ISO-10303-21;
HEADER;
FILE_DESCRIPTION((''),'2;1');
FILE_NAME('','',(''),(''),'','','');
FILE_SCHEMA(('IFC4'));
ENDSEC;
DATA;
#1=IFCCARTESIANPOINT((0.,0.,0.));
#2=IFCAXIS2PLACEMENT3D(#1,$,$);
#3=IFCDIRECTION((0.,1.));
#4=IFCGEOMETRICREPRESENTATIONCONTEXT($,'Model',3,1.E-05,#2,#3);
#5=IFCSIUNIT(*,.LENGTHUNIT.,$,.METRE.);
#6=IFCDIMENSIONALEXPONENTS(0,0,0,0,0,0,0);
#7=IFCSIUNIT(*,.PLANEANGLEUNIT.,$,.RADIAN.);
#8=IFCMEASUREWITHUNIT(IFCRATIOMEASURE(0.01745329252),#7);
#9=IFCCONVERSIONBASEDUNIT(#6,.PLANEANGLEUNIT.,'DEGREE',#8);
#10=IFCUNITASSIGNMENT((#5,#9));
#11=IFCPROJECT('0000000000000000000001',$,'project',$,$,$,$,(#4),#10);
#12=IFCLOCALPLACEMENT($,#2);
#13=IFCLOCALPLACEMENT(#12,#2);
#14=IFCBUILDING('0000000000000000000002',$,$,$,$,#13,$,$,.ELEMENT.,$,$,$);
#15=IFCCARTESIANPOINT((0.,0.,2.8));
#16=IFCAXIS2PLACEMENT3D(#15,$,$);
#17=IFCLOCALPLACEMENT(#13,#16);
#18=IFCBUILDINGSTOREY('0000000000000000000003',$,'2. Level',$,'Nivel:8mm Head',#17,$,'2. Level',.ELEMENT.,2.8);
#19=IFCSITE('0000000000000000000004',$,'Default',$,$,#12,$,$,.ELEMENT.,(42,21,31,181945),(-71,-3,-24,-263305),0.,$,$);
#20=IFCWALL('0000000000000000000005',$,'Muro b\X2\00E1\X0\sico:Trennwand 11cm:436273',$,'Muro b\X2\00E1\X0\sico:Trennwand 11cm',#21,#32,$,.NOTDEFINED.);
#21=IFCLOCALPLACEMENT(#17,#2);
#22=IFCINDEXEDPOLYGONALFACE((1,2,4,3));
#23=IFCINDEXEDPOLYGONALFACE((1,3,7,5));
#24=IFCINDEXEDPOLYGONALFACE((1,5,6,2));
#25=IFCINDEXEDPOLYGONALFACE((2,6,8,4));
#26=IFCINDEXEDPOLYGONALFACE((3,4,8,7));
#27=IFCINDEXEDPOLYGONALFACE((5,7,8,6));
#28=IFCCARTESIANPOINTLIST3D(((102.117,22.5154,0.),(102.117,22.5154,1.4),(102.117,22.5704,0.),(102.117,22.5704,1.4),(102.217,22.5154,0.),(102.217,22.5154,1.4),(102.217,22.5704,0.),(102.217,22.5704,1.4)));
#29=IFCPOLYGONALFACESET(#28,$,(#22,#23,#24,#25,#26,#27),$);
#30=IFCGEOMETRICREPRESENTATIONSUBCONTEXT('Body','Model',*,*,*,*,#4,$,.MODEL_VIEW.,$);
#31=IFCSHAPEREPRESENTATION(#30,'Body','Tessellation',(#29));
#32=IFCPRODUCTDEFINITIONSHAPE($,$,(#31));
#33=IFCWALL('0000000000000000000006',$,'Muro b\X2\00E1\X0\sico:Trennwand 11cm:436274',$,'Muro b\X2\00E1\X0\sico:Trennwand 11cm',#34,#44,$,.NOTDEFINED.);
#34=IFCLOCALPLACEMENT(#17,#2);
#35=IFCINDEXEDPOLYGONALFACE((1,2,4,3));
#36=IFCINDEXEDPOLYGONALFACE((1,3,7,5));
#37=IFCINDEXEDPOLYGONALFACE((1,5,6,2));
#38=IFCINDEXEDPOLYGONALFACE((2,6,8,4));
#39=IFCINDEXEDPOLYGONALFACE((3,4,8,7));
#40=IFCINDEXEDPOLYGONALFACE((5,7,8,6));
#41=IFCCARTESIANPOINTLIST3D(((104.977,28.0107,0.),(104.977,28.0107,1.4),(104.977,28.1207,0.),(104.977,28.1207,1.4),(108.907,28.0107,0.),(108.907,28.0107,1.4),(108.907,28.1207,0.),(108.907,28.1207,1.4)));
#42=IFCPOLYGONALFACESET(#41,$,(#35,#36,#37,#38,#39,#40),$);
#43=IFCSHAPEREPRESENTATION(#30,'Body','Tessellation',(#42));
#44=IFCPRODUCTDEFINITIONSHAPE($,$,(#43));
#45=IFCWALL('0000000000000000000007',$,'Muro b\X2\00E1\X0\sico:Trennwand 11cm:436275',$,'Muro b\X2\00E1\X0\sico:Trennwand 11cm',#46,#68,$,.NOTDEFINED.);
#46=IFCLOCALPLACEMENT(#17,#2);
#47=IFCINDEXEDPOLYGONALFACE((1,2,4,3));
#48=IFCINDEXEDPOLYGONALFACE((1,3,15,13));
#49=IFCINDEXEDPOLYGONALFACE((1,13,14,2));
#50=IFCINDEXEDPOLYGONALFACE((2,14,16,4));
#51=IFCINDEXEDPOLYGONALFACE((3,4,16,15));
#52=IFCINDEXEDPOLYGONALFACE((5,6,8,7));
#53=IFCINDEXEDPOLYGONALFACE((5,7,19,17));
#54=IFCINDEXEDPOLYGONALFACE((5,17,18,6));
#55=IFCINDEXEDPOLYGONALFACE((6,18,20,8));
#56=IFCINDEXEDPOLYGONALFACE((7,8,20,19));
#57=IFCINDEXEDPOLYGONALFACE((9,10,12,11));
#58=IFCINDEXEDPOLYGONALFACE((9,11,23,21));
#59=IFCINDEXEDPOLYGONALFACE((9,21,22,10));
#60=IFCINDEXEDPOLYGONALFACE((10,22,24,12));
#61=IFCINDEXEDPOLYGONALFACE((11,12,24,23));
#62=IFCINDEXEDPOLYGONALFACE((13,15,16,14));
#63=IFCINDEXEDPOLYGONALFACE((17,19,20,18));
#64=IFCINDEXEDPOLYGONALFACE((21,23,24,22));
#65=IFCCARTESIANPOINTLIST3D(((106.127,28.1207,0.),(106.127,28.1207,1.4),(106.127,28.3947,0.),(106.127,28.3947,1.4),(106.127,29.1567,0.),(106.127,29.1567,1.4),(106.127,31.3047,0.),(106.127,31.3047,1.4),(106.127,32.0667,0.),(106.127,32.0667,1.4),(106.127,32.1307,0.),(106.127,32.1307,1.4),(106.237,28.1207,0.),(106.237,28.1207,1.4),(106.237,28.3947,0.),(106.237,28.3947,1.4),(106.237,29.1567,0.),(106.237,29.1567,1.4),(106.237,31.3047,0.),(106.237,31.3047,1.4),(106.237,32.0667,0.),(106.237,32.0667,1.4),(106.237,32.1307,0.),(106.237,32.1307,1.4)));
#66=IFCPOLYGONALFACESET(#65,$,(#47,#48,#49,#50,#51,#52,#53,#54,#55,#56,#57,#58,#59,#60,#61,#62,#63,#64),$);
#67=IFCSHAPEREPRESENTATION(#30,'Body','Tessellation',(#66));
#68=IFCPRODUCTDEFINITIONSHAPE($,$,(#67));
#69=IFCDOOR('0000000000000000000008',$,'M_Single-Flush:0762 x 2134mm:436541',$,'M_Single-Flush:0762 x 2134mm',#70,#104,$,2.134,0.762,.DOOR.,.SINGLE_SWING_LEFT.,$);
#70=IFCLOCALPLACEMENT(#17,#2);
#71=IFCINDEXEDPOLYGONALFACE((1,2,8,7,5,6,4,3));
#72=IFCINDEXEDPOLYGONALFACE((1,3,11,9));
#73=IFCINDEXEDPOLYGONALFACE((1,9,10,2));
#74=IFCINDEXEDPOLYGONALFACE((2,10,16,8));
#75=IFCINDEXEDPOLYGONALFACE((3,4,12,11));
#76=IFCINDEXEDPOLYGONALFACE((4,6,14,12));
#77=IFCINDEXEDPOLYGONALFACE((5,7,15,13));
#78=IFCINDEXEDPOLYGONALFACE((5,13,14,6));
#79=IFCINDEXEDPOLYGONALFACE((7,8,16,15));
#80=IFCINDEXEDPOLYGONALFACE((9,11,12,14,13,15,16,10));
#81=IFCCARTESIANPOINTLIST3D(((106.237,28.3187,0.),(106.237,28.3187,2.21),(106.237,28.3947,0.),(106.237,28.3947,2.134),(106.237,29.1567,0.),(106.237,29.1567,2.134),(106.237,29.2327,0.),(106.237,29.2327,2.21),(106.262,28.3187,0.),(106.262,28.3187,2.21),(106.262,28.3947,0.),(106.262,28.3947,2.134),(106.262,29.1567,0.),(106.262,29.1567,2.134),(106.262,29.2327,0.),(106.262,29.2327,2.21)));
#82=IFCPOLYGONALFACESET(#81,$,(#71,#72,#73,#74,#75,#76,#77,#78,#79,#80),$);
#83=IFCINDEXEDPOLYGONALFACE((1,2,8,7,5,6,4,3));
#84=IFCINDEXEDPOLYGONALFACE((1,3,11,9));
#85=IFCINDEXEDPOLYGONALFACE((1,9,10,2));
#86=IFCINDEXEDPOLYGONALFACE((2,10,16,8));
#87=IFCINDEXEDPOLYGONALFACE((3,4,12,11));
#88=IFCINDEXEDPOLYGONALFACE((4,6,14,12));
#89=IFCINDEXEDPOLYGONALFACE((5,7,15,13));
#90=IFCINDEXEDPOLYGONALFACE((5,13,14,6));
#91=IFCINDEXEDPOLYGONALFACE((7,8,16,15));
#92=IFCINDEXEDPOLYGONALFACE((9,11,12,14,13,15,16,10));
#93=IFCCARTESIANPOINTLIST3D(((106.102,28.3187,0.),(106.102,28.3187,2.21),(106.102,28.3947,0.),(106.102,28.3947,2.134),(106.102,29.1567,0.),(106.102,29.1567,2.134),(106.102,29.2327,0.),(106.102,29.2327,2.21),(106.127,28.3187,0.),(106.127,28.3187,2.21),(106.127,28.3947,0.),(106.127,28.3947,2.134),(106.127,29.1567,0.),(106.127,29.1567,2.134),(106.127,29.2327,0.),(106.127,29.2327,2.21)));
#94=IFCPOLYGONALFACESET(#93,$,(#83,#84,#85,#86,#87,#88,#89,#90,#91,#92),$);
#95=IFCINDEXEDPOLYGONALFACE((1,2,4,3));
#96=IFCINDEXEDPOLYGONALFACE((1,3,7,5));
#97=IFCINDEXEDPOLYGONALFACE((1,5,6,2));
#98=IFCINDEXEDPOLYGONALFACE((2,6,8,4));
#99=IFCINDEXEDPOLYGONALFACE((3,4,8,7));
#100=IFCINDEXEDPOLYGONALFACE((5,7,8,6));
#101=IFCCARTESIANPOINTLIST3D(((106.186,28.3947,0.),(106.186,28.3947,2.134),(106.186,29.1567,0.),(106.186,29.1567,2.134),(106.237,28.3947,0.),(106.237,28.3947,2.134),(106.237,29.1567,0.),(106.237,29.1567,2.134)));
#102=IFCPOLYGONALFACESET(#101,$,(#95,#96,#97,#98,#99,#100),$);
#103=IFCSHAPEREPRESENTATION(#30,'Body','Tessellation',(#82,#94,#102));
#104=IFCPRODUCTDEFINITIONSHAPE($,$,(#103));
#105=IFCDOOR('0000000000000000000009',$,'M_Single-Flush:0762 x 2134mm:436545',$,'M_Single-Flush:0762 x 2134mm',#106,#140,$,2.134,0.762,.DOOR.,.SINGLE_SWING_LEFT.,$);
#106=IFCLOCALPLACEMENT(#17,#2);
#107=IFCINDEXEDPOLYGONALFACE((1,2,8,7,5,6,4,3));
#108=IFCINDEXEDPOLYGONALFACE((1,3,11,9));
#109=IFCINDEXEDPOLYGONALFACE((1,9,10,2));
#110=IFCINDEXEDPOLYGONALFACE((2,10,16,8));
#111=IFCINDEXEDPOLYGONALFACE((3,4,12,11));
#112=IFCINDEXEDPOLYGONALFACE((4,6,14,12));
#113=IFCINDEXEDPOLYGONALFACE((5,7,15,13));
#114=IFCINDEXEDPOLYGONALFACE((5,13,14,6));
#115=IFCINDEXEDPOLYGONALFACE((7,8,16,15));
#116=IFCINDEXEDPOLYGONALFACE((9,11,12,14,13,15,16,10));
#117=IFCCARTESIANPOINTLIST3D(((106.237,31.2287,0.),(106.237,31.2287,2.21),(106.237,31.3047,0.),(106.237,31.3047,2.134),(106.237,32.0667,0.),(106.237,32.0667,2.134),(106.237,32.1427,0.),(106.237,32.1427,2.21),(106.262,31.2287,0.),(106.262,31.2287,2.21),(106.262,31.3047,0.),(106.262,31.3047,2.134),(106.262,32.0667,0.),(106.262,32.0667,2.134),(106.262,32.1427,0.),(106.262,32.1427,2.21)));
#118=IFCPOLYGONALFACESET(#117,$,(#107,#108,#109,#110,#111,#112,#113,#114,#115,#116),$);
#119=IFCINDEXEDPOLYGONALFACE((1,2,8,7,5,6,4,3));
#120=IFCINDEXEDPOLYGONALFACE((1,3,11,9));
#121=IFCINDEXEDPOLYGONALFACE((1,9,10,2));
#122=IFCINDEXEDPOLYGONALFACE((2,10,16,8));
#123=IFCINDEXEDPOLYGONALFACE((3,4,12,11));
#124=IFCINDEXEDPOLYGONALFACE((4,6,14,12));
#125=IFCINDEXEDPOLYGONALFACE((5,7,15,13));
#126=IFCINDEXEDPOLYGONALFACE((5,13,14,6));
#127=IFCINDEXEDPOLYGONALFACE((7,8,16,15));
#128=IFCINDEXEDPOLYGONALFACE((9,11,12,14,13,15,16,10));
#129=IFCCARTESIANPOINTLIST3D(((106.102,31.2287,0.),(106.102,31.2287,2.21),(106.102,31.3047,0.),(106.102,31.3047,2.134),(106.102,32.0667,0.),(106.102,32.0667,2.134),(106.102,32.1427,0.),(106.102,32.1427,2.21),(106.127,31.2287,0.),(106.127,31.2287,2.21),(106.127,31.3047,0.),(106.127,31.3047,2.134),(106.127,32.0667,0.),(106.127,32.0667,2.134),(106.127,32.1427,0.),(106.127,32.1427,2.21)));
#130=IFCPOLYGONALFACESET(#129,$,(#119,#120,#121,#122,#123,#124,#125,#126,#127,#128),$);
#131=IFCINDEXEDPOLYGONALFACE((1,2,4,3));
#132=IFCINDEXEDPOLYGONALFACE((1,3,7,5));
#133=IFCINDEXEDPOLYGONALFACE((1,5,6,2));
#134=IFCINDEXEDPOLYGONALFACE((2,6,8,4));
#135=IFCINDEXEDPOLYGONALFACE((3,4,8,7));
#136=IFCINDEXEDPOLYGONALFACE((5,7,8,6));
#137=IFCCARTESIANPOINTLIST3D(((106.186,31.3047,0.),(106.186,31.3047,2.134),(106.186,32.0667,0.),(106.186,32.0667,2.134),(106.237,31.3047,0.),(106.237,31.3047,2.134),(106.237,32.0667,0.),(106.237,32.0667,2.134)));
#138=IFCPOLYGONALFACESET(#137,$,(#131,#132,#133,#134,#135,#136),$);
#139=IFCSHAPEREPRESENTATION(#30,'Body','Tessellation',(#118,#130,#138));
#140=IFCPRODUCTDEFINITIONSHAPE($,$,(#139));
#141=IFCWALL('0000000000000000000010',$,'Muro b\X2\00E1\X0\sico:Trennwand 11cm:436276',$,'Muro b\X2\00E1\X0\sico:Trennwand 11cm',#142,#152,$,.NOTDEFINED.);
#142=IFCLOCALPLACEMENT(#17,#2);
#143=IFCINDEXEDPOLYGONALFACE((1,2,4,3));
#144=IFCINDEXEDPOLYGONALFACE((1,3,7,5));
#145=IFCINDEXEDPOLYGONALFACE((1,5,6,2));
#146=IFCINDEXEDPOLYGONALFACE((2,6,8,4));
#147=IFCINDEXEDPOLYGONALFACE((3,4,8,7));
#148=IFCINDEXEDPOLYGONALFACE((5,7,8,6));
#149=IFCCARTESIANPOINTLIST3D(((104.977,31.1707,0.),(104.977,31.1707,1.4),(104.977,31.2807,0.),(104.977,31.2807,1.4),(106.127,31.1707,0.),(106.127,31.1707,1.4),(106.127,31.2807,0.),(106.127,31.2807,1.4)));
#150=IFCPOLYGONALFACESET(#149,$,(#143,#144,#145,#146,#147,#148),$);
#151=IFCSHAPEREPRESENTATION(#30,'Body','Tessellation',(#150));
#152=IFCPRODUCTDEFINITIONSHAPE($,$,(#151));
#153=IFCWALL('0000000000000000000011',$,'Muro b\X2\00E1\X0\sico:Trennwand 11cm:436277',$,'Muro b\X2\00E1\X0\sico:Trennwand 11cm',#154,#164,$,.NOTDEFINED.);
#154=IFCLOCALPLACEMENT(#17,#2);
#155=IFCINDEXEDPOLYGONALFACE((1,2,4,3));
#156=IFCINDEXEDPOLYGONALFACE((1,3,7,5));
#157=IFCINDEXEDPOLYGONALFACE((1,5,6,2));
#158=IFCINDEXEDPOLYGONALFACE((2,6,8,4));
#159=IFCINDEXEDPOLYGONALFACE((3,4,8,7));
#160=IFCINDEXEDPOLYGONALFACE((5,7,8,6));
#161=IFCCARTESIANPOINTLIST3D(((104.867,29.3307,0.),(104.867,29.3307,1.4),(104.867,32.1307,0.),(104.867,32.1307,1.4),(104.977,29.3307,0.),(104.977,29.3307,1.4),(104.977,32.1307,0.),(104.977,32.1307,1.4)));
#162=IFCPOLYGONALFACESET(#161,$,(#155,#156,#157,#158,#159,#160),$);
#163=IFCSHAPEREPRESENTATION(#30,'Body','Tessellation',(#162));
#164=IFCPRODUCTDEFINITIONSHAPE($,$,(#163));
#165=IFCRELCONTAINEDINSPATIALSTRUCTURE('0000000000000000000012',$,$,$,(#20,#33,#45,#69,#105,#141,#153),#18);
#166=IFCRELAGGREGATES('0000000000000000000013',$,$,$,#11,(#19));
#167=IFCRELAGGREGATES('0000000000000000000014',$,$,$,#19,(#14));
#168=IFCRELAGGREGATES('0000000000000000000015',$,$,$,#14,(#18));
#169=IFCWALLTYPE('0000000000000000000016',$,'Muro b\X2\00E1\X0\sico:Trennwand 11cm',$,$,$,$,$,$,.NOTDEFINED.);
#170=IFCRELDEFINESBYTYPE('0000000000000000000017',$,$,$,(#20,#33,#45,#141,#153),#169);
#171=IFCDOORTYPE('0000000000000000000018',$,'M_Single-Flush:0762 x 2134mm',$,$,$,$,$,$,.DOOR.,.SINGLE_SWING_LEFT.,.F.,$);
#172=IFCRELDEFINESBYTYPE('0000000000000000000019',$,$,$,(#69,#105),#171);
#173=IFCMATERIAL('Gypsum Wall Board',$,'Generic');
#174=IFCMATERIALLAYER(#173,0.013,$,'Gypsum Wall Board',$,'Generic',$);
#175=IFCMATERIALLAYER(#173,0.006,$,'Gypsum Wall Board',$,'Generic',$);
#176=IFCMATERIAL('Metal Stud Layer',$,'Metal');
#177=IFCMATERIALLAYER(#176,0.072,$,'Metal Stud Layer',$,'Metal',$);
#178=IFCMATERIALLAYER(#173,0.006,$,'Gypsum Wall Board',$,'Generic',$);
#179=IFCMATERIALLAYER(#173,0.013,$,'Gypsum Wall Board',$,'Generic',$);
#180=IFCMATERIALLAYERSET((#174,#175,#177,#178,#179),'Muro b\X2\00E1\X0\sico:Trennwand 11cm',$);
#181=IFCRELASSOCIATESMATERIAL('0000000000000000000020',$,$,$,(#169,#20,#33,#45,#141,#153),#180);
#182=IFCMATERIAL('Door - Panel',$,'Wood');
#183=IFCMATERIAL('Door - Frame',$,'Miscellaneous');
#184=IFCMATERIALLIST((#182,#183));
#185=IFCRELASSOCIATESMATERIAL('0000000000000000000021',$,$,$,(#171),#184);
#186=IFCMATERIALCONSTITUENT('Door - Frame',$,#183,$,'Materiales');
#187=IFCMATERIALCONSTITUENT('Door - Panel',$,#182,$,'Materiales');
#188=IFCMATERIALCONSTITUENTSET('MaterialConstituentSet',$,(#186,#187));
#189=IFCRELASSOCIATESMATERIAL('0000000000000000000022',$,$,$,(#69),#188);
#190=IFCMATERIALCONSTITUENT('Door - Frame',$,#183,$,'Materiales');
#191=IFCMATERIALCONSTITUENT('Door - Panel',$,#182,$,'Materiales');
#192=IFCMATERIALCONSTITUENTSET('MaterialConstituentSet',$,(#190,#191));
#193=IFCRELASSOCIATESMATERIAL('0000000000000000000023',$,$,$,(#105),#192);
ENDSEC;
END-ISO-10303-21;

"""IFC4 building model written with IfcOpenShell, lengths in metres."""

from ifc_helpers import new_model, entity, si_unit, converted_unit, direction, frame, frame_2d, origin, origin_2d_with_axis, place, context, subcontext, project, spatial, polyline, rectangle, outline, extrude, clip, halfspace, source, transform, mapped, material, material_list, layer, layer_set, layer_usage, constituent, constituent_set, type_object, type_shapes, element, fill, save


model = new_model("IFC4")

# Units and contexts
model_context = context("Model", 3, precision=1e-05, world=origin(), true_north=direction((0.0, 1.0)))
body_context = subcontext(model_context, "Body", "Model", "MODEL_VIEW")
ifc_project = project(units=[si_unit("LENGTHUNIT", "METRE"), converted_unit("PLANEANGLEUNIT", "DEGREE", entity("IfcRatioMeasure", 0.01745329252), si_unit("PLANEANGLEUNIT", "RADIAN"), dimensions=[0, 0, 0, 0, 0, 0, 0])], contexts=[model_context])

# Site, building, storey
site_placement = place(None, origin())
site = spatial("IfcSite", under=ifc_project, at=site_placement, Name="Default", CompositionType="ELEMENT", RefLatitude=(42, 21, 31, 181945), RefLongitude=(-71, -3, -24, -263305), RefElevation=0.0)
building_placement = place(site_placement, origin())
building = spatial("IfcBuilding", under=site, at=building_placement, CompositionType="ELEMENT")
storey_placement = place(building_placement, frame((0.0, 0.0, 2.8)))
storey = spatial("IfcBuildingStorey", under=building, at=storey_placement, Name="2. Level", ObjectType="Nivel:8mm Head", LongName="2. Level", CompositionType="ELEMENT", Elevation=2.8)

# Walls
ifc_material_1 = material(Name="Gypsum Wall Board", Category="Generic")
ifc_layer_1 = layer(ifc_material_1, 0.013, Name="Gypsum Wall Board", Category="Generic")
ifc_layer_2 = layer(ifc_material_1, 0.006, Name="Gypsum Wall Board", Category="Generic")
ifc_material_2 = material(Name="Metal Stud Layer", Category="Metal")
ifc_layer_3 = layer(ifc_material_2, 0.072, Name="Metal Stud Layer", Category="Metal")
ifc_layer_4 = layer(ifc_material_1, 0.006, Name="Gypsum Wall Board", Category="Generic")
ifc_layer_5 = layer(ifc_material_1, 0.013, Name="Gypsum Wall Board", Category="Generic")
ifc_layer_set_1 = layer_set([ifc_layer_1, ifc_layer_2, ifc_layer_3, ifc_layer_4, ifc_layer_5], Name="Muro básico:Trennwand 11cm")
ifc_layer_usage_1 = layer_usage(ifc_layer_set_1, "AXIS2", "NEGATIVE", 0.055)
wall_type_1 = type_object("IfcWallType", Name="Muro básico:Trennwand 11cm", PredefinedType="NOTDEFINED", material=ifc_layer_set_1)
wall_1_placement = place(storey_placement, frame((102.117, 22.5154, 0.0)))
element("IfcWall", 1, at=wall_1_placement, inside=storey, type_object=wall_type_1, material=ifc_layer_usage_1, Name="Muro básico:Trennwand 11cm:436273", ObjectType="Muro básico:Trennwand 11cm", PredefinedType="NOTDEFINED", context=body_context, shape_type="SweptSolid", body=[
    extrude(rectangle(XDim=0.055, YDim=0.1, at=origin_2d_with_axis()), frame((0.05, 0.0275, 0.0), z_axis=(0.0, 0.0, 1.0), x_axis=(0.0, -1.0, 0.0)), (0.0, 0.0, 1.0), 1.4),
])
ifc_layer_usage_2 = layer_usage(ifc_layer_set_1, "AXIS2", "NEGATIVE", 0.055)
wall_2_placement = place(storey_placement, frame((104.977, 28.0657, 0.0)))
element("IfcWall", 2, at=wall_2_placement, inside=storey, type_object=wall_type_1, material=ifc_layer_usage_2, Name="Muro básico:Trennwand 11cm:436274", ObjectType="Muro básico:Trennwand 11cm", PredefinedType="NOTDEFINED", context=body_context, shape_type="Clipping", body=[
    clip(extrude(rectangle(XDim=3.93, YDim=0.11, at=frame_2d((1.965, 0.0), x_axis=(-1.0, 0.0))), origin(), (0.0, 0.0, 1.0), 1.4), halfspace(origin(), True)),
])

# Wall, openings, doors
ifc_layer_usage_3 = layer_usage(ifc_layer_set_1, "AXIS2", "NEGATIVE", 0.055)
wall_3_placement = place(storey_placement, frame((106.182, 32.1307, 0.0), z_axis=(0.0, 0.0, 1.0), x_axis=(0.0, -1.0, 0.0)))
wall_3 = element("IfcWall", 3, at=wall_3_placement, inside=storey, type_object=wall_type_1, material=ifc_layer_usage_3, Name="Muro básico:Trennwand 11cm:436275", ObjectType="Muro básico:Trennwand 11cm", PredefinedType="NOTDEFINED", context=body_context, shape_type="Clipping", body=[
    clip(extrude(rectangle(XDim=4.01, YDim=0.11, at=frame_2d((2.005, 0.0), x_axis=(-1.0, 0.0))), origin(), (0.0, 0.0, 1.0), 1.4), halfspace(origin(), True)),
])
opening_1_placement = place(wall_3_placement, frame((2.974, -0.055, 0.0)))
opening_1 = element("IfcOpeningElement", 4, at=opening_1_placement, cuts=wall_3, ObjectType="Opening", PredefinedType="OPENING", context=body_context, shape_type="SweptSolid", body=[
    extrude(rectangle(XDim=0.762, YDim=2.134, at=frame_2d((1.067, 0.381), x_axis=(0.0, -1.0))), frame((0.0, 0.0, 0.0), z_axis=(0.0, 1.0, 0.0), x_axis=(0.0, 0.0, 1.0)), (0.0, 0.0, 1.0), 0.11),
])
opening_2_placement = place(wall_3_placement, frame((0.064, -0.055, 0.0)))
opening_2 = element("IfcOpeningElement", 5, at=opening_2_placement, cuts=wall_3, ObjectType="Opening", PredefinedType="OPENING", context=body_context, shape_type="SweptSolid", body=[
    extrude(rectangle(XDim=0.762, YDim=2.134, at=frame_2d((1.067, 0.381), x_axis=(0.0, -1.0))), frame((0.0, 0.0, 0.0), z_axis=(0.0, 1.0, 0.0), x_axis=(0.0, 0.0, 1.0)), (0.0, 0.0, 1.0), 0.11),
])
ifc_material_3 = material(Name="Door - Frame", Category="Miscellaneous")
ifc_constituent_1 = constituent(ifc_material_3, Name="Door - Frame", Category="Materiales")
ifc_material_4 = material(Name="Door - Panel", Category="Wood")
ifc_constituent_2 = constituent(ifc_material_4, Name="Door - Panel", Category="Materiales")
ifc_constituent_set_1 = constituent_set(constituents=[ifc_constituent_1, ifc_constituent_2], Name="MaterialConstituentSet")
ifc_material_list_1 = material_list([ifc_material_4, ifc_material_3])
door_type_1 = type_object("IfcDoorType", Name="M_Single-Flush:0762 x 2134mm", OperationType="SINGLE_SWING_LEFT", ParameterTakesPrecedence=False, PredefinedType="DOOR", material=ifc_material_list_1)
shared_shape_1 = source(origin(), body_context, "Body", "SweptSolid", [
    extrude(outline(polyline([(-0.457, -1.124), (0.457, -1.124), (0.457, 1.086), (0.381, 1.086), (0.381, -1.048), (-0.381, -1.048), (-0.381, 1.086), (-0.457, 1.086), (-0.457, -1.124)])), frame((0.381, 0.135, 1.086), z_axis=(0.0, -1.0, 0.0), x_axis=(-1.0, 0.0, 0.0)), (0.0, 0.0, 1.0), 0.025),
    extrude(outline(polyline([(-1.124, -0.457), (1.086, -0.457), (1.086, -0.381), (-1.048, -0.381), (-1.048, 0.381), (1.086, 0.381), (1.086, 0.457), (-1.124, 0.457), (-1.124, -0.457)])), frame((0.381, 0.0, 1.086), z_axis=(0.0, -1.0, 0.0), x_axis=(0.0, 0.0, -1.0)), (0.0, 0.0, 1.0), 0.025),
    extrude(rectangle(XDim=0.762, YDim=0.051, at=origin_2d_with_axis()), frame((0.381, 0.0845, 0.0)), (0.0, 0.0, 1.0), 2.134),
])
type_shapes(door_type_1, [shared_shape_1])
door_1_placement = place(opening_1_placement, origin())
door_1 = element("IfcDoor", 6, at=door_1_placement, inside=storey, type_object=door_type_1, material=ifc_constituent_set_1, Name="M_Single-Flush:0762 x 2134mm:436541", ObjectType="M_Single-Flush:0762 x 2134mm", OperationType="SINGLE_SWING_LEFT", OverallHeight=2.134, OverallWidth=0.762, PredefinedType="DOOR", context=body_context, shape_type="MappedRepresentation", body=[
    mapped(shared_shape_1, transform((0.0, 0.0, 0.0), scale=1.0)),
])
fill(opening_1, door_1)
ifc_constituent_3 = constituent(ifc_material_3, Name="Door - Frame", Category="Materiales")
ifc_constituent_4 = constituent(ifc_material_4, Name="Door - Panel", Category="Materiales")
ifc_constituent_set_2 = constituent_set(constituents=[ifc_constituent_3, ifc_constituent_4], Name="MaterialConstituentSet")
door_2_placement = place(opening_2_placement, origin())
door_2 = element("IfcDoor", 7, at=door_2_placement, inside=storey, type_object=door_type_1, material=ifc_constituent_set_2, Name="M_Single-Flush:0762 x 2134mm:436545", ObjectType="M_Single-Flush:0762 x 2134mm", OperationType="SINGLE_SWING_LEFT", OverallHeight=2.134, OverallWidth=0.762, PredefinedType="DOOR", context=body_context, shape_type="MappedRepresentation", body=[
    mapped(shared_shape_1, transform((0.0, 0.0, 0.0), scale=1.0)),
])
fill(opening_2, door_2)

# Walls
ifc_layer_usage_4 = layer_usage(ifc_layer_set_1, "AXIS2", "NEGATIVE", 0.055)
wall_4_placement = place(storey_placement, frame((106.127, 31.2257, 0.0), z_axis=(0.0, 0.0, 1.0), x_axis=(-1.0, 0.0, 0.0)))
element("IfcWall", 8, at=wall_4_placement, inside=storey, type_object=wall_type_1, material=ifc_layer_usage_4, Name="Muro básico:Trennwand 11cm:436276", ObjectType="Muro básico:Trennwand 11cm", PredefinedType="NOTDEFINED", context=body_context, shape_type="Clipping", body=[
    clip(extrude(rectangle(XDim=1.15, YDim=0.11, at=frame_2d((0.575, 0.0), x_axis=(-1.0, 0.0))), origin(), (0.0, 0.0, 1.0), 1.4), halfspace(origin(), True)),
])
ifc_layer_usage_5 = layer_usage(ifc_layer_set_1, "AXIS2", "NEGATIVE", 0.055)
wall_5_placement = place(storey_placement, frame((104.922, 32.1307, 0.0), z_axis=(0.0, 0.0, 1.0), x_axis=(0.0, -1.0, 0.0)))
element("IfcWall", 9, at=wall_5_placement, inside=storey, type_object=wall_type_1, material=ifc_layer_usage_5, Name="Muro básico:Trennwand 11cm:436277", ObjectType="Muro básico:Trennwand 11cm", PredefinedType="NOTDEFINED", context=body_context, shape_type="Clipping", body=[
    clip(extrude(rectangle(XDim=2.8, YDim=0.11, at=frame_2d((1.4, 0.0), x_axis=(-1.0, 0.0))), origin(), (0.0, 0.0, 1.0), 1.4), halfspace(origin(), True)),
])

save(model, "model.ifc")
